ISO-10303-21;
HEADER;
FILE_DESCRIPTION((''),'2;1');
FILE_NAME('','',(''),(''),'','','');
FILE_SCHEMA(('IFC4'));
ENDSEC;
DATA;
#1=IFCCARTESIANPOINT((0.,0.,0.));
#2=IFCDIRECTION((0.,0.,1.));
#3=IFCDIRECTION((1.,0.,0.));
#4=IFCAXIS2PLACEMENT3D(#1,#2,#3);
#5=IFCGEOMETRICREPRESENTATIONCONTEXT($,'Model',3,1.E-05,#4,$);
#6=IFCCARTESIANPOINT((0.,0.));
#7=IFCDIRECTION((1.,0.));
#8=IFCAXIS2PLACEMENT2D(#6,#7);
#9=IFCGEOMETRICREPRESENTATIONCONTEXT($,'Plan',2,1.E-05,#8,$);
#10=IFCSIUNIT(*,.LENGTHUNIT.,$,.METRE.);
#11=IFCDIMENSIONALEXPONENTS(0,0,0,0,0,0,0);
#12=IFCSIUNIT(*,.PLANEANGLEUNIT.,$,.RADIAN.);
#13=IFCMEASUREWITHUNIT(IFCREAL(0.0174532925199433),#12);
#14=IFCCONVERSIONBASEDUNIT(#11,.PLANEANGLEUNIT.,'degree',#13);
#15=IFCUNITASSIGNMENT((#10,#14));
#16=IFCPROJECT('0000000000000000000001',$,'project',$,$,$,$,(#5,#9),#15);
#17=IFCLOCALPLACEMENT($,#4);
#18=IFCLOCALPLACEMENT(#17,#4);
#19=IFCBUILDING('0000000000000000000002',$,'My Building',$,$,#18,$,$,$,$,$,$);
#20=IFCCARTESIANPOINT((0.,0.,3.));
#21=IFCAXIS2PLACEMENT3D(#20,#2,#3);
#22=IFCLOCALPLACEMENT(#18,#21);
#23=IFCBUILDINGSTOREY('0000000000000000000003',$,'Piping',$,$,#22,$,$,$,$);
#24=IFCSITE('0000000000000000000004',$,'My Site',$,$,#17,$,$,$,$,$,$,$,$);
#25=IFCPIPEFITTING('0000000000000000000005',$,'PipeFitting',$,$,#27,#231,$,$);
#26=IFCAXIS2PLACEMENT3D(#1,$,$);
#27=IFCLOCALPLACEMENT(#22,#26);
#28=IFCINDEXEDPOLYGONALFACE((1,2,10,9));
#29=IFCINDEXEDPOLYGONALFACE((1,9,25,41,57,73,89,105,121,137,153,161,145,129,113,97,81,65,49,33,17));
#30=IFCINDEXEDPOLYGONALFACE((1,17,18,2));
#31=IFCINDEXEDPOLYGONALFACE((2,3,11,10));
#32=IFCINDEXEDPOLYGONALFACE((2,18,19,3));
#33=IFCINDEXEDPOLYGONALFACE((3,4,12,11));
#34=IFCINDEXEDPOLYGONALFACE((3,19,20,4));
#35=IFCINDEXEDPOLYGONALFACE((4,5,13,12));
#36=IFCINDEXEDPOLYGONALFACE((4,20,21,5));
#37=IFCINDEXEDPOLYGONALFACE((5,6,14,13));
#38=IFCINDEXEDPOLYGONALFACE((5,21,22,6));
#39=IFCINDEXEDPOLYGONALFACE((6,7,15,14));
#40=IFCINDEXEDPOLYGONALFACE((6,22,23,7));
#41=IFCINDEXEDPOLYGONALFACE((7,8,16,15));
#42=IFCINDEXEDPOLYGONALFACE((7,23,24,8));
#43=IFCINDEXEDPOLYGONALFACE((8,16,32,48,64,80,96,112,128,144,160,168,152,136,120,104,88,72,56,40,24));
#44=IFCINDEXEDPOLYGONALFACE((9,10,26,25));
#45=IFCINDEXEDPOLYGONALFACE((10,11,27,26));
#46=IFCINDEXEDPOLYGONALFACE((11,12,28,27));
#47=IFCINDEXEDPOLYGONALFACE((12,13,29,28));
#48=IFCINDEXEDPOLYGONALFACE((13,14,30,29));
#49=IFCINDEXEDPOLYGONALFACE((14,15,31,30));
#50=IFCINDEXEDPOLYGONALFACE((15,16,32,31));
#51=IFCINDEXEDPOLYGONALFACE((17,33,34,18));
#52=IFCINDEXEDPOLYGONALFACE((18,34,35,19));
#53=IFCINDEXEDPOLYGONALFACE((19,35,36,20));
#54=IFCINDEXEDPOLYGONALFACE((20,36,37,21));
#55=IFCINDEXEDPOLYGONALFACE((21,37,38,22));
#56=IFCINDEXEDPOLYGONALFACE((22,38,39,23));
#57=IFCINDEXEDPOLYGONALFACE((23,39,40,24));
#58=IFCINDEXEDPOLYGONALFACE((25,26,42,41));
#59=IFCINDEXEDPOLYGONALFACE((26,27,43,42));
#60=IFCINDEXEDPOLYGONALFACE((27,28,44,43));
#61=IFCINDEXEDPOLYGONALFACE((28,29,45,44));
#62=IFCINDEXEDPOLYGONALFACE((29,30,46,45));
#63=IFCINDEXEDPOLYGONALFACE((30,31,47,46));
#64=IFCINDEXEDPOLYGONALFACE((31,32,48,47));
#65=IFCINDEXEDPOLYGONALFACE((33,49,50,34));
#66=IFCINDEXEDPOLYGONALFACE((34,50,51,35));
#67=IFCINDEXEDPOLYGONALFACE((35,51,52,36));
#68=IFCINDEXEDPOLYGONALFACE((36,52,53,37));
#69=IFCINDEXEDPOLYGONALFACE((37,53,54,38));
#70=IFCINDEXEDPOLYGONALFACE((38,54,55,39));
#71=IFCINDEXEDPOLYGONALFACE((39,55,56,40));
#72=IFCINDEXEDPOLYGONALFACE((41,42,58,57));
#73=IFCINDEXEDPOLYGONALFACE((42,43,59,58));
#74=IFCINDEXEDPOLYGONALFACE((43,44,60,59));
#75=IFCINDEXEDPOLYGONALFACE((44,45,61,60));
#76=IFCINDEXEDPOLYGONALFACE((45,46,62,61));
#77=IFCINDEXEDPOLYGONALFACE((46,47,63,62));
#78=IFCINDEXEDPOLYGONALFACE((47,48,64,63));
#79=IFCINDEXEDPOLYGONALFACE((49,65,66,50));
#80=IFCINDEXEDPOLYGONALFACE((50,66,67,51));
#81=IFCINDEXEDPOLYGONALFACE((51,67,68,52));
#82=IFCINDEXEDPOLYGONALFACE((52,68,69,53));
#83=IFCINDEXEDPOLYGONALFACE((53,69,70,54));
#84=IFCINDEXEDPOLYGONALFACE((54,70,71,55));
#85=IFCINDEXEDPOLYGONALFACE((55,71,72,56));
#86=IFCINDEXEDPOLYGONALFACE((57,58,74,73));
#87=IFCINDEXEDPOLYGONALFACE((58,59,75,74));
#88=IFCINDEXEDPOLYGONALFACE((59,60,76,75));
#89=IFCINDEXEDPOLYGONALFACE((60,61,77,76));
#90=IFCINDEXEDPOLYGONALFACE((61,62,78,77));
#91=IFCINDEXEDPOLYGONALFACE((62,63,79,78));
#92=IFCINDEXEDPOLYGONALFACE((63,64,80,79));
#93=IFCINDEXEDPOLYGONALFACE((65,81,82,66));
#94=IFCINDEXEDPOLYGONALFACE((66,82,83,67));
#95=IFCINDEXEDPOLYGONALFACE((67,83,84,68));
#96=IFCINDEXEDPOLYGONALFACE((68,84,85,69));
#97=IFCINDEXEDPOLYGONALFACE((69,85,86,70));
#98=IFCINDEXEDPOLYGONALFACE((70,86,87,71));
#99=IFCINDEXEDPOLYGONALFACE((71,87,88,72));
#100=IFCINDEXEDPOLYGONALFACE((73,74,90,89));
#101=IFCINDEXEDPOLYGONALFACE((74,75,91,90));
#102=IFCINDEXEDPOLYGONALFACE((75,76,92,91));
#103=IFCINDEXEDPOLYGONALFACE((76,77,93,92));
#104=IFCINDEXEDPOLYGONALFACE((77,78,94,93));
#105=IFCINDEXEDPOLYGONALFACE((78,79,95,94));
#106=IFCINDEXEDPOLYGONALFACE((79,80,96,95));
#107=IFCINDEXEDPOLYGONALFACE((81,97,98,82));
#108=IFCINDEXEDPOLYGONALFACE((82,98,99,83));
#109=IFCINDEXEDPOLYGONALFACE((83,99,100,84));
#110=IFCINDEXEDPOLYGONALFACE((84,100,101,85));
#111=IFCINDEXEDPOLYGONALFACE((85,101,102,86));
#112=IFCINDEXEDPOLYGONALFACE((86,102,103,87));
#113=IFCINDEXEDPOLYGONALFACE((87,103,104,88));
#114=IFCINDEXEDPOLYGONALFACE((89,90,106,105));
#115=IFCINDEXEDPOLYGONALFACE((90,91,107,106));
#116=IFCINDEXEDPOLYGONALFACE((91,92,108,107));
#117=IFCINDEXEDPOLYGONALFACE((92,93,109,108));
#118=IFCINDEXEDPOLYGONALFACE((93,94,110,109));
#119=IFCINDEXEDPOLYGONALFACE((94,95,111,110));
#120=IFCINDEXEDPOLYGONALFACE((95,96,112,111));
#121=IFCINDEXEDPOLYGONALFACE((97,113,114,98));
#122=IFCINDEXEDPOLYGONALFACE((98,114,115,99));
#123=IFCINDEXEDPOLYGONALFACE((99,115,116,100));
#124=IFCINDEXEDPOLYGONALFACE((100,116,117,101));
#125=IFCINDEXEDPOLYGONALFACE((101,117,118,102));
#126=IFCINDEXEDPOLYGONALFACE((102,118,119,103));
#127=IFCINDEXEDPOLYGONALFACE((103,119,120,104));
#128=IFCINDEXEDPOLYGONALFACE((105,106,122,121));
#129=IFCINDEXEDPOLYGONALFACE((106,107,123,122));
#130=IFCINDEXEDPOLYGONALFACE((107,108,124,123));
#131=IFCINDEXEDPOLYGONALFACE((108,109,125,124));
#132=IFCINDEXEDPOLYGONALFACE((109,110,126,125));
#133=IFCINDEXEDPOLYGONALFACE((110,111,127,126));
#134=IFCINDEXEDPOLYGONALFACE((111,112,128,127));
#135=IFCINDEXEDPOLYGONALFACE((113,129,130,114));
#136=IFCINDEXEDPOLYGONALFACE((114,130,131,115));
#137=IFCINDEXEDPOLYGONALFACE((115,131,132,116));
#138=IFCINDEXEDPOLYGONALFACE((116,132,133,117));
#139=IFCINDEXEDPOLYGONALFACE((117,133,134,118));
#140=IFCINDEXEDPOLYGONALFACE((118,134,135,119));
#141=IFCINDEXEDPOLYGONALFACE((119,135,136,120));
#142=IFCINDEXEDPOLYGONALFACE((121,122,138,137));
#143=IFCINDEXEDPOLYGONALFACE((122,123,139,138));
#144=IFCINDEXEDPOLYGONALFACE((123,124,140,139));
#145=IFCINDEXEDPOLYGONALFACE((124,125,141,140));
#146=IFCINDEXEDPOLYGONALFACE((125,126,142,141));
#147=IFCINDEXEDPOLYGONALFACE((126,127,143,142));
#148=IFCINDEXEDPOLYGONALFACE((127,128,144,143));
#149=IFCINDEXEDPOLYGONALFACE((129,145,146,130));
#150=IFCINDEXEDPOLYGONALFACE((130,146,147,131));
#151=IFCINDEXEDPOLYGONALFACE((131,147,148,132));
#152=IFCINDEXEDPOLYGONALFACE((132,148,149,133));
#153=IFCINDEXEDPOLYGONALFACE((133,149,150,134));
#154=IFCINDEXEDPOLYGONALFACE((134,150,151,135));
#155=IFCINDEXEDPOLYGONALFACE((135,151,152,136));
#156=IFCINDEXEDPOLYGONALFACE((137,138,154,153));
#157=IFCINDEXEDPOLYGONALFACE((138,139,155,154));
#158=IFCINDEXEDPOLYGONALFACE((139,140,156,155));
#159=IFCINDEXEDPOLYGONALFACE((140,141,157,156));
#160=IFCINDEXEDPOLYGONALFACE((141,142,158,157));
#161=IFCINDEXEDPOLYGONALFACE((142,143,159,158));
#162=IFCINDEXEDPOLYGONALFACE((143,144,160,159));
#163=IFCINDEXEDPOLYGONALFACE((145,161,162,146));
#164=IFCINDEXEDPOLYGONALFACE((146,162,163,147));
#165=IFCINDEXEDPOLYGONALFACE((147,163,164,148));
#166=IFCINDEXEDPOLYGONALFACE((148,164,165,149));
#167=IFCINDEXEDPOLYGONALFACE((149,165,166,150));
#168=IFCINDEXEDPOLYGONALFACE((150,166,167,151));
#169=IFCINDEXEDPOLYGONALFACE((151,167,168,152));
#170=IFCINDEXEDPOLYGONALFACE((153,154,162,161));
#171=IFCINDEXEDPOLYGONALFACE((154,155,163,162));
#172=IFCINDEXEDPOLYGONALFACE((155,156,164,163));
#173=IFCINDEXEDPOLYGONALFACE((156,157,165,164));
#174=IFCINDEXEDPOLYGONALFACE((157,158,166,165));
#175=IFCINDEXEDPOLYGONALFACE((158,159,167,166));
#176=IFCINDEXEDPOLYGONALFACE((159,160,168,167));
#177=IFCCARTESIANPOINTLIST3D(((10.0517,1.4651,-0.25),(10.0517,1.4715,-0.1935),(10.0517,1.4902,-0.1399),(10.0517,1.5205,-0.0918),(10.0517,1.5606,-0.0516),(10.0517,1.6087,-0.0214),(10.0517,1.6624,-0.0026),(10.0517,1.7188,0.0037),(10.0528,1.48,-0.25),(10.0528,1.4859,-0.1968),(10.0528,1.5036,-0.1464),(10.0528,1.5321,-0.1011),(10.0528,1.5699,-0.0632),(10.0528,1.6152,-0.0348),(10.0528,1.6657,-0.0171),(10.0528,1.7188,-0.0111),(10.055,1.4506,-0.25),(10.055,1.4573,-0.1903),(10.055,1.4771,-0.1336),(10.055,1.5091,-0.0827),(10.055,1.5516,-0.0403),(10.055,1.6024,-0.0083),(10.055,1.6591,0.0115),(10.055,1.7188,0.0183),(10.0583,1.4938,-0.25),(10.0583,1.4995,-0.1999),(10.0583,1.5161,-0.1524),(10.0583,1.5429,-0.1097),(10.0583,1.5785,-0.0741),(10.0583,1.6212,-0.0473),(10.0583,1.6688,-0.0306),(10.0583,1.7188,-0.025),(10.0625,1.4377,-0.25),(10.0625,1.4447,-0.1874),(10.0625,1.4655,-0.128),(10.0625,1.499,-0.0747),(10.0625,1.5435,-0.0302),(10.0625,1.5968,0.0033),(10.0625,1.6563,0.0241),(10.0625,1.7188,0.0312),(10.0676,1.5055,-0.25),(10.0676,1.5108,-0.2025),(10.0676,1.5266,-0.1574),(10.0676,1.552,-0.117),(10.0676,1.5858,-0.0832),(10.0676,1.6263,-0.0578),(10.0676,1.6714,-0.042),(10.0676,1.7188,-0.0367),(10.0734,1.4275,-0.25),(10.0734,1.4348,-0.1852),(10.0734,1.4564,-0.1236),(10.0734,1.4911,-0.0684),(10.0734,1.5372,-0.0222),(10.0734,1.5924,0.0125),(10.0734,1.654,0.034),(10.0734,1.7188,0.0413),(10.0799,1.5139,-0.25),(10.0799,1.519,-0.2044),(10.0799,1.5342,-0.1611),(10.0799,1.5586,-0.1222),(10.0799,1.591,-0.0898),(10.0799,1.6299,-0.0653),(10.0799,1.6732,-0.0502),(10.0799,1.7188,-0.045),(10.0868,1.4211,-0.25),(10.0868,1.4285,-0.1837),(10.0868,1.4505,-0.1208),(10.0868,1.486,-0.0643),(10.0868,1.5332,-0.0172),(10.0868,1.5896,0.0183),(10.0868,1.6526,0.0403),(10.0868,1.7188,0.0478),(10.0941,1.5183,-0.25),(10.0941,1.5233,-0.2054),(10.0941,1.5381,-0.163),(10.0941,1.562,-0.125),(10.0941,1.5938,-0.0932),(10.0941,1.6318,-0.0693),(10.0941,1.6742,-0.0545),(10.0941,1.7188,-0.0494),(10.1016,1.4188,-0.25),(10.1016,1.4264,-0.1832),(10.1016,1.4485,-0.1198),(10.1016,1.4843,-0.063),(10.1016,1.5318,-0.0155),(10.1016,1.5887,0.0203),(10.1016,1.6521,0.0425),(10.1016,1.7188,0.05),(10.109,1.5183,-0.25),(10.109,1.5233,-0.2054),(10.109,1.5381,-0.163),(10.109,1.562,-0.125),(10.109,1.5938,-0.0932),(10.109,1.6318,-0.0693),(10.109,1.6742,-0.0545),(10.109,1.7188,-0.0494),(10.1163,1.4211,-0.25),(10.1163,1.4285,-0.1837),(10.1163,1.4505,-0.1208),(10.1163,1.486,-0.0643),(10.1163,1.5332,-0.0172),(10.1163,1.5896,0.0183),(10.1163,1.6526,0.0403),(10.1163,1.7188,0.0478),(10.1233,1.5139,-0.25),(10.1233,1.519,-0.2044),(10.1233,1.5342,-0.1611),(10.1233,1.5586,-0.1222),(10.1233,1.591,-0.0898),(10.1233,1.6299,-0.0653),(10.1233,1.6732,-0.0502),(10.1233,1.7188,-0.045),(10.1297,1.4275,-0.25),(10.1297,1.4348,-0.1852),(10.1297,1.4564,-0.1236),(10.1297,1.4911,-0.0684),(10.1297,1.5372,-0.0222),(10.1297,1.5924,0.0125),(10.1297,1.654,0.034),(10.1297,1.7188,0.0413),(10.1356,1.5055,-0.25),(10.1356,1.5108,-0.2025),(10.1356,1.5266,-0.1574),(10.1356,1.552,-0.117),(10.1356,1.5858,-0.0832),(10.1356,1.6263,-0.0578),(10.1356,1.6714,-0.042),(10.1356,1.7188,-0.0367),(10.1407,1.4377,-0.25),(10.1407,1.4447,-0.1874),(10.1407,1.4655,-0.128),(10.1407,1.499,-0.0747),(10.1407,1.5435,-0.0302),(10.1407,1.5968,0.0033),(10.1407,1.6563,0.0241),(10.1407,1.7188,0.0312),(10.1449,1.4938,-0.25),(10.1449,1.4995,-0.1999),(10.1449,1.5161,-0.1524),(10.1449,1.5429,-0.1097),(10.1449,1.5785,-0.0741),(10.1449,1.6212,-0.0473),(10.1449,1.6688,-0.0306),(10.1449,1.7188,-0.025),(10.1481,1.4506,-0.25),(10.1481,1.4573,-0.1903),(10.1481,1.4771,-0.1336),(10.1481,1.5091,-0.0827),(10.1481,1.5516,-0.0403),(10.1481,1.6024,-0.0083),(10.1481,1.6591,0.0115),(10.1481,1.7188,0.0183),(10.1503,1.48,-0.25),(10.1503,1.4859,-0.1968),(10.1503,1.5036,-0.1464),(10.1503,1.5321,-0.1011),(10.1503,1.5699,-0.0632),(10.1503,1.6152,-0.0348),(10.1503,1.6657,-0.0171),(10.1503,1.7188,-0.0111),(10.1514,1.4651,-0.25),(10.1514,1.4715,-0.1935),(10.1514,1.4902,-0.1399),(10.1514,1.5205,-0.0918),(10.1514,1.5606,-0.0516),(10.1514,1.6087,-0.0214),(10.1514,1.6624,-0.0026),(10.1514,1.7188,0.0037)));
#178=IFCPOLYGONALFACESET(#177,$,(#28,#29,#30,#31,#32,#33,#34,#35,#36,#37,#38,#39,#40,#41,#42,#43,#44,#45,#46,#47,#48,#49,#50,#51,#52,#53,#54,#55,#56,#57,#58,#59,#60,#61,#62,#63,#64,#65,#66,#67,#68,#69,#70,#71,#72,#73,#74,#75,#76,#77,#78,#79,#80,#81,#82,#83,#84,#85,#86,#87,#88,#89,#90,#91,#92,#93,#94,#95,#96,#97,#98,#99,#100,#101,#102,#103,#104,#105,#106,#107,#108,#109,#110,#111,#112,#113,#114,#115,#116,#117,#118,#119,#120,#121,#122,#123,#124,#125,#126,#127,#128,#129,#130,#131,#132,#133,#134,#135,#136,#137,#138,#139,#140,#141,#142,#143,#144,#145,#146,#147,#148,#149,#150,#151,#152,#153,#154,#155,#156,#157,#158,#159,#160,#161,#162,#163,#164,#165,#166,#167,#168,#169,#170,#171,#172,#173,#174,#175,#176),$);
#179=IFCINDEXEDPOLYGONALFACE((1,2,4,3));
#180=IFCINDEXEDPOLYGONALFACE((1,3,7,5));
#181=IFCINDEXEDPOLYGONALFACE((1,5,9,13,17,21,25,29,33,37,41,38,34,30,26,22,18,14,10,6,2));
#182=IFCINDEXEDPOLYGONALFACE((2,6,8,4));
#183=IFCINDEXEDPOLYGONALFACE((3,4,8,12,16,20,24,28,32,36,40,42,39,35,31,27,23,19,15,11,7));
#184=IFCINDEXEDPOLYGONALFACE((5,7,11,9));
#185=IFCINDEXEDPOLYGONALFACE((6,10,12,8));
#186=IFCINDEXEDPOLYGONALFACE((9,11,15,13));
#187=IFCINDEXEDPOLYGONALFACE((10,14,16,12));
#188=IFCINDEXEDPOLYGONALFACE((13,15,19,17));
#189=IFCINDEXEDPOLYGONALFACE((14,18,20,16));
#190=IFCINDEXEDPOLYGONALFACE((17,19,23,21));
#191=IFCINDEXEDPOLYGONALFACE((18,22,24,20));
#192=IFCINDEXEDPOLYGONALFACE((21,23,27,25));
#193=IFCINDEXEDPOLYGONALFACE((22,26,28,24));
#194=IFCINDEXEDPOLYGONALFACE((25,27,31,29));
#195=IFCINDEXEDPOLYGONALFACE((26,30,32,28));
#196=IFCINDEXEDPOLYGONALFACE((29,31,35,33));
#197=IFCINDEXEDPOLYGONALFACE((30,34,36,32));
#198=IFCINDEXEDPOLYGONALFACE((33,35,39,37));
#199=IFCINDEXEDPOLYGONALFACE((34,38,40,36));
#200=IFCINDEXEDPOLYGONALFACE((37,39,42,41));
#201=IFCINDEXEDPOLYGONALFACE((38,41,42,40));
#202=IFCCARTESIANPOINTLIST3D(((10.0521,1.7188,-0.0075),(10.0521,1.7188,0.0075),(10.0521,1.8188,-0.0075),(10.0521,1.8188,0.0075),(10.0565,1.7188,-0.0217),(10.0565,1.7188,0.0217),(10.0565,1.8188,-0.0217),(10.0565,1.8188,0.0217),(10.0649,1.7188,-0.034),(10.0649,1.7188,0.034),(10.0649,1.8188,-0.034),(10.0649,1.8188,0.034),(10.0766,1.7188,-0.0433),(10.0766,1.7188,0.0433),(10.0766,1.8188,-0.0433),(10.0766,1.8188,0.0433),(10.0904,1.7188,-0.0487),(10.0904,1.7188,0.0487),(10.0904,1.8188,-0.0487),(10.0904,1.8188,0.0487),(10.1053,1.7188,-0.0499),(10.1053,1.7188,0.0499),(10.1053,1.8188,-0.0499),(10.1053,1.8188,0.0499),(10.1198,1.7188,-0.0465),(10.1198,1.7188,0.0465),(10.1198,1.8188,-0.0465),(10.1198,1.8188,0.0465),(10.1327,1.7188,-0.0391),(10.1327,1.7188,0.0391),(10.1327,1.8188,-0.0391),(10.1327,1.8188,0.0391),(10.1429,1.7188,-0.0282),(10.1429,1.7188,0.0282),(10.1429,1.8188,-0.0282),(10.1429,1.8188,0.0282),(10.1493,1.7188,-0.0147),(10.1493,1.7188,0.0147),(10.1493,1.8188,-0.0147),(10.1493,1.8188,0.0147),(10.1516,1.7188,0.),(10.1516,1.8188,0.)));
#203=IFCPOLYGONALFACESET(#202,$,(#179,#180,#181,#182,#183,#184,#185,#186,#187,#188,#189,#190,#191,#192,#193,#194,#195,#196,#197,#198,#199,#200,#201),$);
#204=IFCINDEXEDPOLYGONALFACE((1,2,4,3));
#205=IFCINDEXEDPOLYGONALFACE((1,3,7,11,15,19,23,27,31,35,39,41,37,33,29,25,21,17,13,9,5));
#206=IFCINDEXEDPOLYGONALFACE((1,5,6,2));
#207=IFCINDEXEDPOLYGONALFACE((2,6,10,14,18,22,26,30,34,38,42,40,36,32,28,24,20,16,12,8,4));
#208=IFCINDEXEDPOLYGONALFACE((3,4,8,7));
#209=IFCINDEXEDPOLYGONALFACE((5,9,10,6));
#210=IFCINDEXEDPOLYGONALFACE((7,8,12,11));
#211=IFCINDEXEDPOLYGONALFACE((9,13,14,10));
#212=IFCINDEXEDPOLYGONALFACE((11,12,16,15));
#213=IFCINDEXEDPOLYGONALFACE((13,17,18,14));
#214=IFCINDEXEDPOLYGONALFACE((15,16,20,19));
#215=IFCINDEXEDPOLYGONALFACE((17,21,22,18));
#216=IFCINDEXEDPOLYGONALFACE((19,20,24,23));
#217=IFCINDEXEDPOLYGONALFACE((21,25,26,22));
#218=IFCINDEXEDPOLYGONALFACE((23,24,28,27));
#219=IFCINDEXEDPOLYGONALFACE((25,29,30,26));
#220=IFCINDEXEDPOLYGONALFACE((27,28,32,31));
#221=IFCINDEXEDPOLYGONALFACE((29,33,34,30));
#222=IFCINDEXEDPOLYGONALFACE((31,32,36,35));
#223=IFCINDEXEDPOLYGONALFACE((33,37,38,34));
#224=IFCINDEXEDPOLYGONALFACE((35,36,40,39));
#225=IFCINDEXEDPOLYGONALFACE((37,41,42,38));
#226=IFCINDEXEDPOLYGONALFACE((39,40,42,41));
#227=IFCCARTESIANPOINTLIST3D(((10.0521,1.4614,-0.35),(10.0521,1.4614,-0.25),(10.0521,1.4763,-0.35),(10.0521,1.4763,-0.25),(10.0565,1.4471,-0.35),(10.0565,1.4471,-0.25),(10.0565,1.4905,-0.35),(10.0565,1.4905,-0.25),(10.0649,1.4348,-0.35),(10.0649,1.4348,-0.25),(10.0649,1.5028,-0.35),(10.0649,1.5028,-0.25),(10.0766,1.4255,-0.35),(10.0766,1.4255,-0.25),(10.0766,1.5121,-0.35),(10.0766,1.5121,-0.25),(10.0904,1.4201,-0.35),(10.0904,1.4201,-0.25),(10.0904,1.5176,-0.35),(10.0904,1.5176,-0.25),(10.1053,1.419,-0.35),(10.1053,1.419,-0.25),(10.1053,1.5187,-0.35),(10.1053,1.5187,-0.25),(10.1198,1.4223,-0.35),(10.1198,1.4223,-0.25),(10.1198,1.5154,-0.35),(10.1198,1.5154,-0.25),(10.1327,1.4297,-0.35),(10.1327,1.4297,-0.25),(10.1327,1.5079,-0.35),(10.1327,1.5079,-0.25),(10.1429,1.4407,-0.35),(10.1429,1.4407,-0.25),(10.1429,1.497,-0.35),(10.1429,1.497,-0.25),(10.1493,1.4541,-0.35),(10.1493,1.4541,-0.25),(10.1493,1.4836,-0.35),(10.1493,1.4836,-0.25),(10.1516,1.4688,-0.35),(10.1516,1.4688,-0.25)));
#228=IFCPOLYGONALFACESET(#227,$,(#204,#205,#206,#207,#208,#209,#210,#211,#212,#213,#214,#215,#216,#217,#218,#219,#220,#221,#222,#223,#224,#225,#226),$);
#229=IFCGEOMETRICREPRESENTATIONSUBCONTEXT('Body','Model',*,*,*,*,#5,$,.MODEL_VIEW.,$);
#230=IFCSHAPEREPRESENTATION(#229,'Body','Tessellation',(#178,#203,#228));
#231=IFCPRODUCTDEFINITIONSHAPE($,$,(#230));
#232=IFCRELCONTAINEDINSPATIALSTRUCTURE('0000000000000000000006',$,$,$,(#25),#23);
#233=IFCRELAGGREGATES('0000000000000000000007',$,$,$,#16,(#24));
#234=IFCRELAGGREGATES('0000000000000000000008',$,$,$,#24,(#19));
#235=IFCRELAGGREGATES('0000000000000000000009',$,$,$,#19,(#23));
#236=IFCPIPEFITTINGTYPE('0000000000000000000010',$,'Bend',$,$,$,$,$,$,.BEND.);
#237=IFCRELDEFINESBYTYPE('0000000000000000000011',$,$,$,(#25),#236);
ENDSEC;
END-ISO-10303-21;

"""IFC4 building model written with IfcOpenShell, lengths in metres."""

from ifc_helpers import new_model, entity, si_unit, converted_unit, frame, origin_with_axes, origin_2d_with_axis, place, context, subcontext, project, spatial, circle, extrude, source, transform, mapped, type_object, type_shapes, element, save


model = new_model("IFC4")

# Units and contexts
model_context = context("Model", 3, precision=1e-05, world=origin_with_axes())
plan_context = context("Plan", 2, precision=1e-05, world=origin_2d_with_axis())
body_context = subcontext(model_context, "Body", "Model", "MODEL_VIEW")
ifc_project = project(units=[si_unit("LENGTHUNIT", "METRE"), converted_unit("PLANEANGLEUNIT", "degree", entity("IfcReal", 0.0174532925199433), si_unit("PLANEANGLEUNIT", "RADIAN"), dimensions=[0, 0, 0, 0, 0, 0, 0])], contexts=[model_context, plan_context])

# Site, building, storey
site_placement = place(None, origin_with_axes())
site = spatial("IfcSite", under=ifc_project, at=site_placement, Name="My Site")
building_placement = place(site_placement, origin_with_axes())
building = spatial("IfcBuilding", under=site, at=building_placement, Name="My Building")
storey_placement = place(building_placement, frame((0.0, 0.0, 3.0), z_axis=(0.0, 0.0, 1.0), x_axis=(1.0, 0.0, 0.0)))
storey = spatial("IfcBuildingStorey", under=building, at=storey_placement, Name="Piping")

# Pipe fitting
pipe_fitting_type = type_object("IfcPipeFittingType", Name="Bend", PredefinedType="BEND")
shared_shape = source(origin_with_axes(), body_context, "Body", "SolidModel", [
    entity("IfcSweptDiskSolid", entity("IfcIndexedPolyCurve", entity("IfcCartesianPointList3D", [[0.0, 0.0, -0.1], [0.0, 0.0732, -0.2768], [0.0, 0.25, -0.35]]), [entity("IfcArcIndex", [1, 2, 3])]), 0.05),
    extrude(circle(Radius=0.05), origin_with_axes(), (0.0, 0.0, -1.0), 0.1),
    extrude(circle(Radius=0.05), frame((0.0, 0.25, -0.35), z_axis=(0.0, 1.0, 0.0), x_axis=(1.0, 0.0, 0.0)), (0.0, 0.0, 1.0), 0.1),
])
type_shapes(pipe_fitting_type, [shared_shape])
for number, where, z_axis, x_axis, name in (
    (1, (10.1016, 1.8188, 0.0), (0.0, 1.0, 0.0), (1.0, 0.0, 0.0), "PipeFitting"),
):
    element("IfcPipeFitting", number, at=place(storey_placement, frame(where, z_axis=z_axis, x_axis=x_axis)), inside=storey, type_object=pipe_fitting_type, Name=name, context=body_context, shape_type="MappedRepresentation", body=[
        mapped(shared_shape, transform((0.0, 0.0, 0.0), x_axis=(1.0, 0.0, 0.0), y_axis=(0.0, 1.0, 0.0), z_axis=(0.0, 0.0, 1.0), scale=1.0)),
    ])

save(model, "model.ifc")
